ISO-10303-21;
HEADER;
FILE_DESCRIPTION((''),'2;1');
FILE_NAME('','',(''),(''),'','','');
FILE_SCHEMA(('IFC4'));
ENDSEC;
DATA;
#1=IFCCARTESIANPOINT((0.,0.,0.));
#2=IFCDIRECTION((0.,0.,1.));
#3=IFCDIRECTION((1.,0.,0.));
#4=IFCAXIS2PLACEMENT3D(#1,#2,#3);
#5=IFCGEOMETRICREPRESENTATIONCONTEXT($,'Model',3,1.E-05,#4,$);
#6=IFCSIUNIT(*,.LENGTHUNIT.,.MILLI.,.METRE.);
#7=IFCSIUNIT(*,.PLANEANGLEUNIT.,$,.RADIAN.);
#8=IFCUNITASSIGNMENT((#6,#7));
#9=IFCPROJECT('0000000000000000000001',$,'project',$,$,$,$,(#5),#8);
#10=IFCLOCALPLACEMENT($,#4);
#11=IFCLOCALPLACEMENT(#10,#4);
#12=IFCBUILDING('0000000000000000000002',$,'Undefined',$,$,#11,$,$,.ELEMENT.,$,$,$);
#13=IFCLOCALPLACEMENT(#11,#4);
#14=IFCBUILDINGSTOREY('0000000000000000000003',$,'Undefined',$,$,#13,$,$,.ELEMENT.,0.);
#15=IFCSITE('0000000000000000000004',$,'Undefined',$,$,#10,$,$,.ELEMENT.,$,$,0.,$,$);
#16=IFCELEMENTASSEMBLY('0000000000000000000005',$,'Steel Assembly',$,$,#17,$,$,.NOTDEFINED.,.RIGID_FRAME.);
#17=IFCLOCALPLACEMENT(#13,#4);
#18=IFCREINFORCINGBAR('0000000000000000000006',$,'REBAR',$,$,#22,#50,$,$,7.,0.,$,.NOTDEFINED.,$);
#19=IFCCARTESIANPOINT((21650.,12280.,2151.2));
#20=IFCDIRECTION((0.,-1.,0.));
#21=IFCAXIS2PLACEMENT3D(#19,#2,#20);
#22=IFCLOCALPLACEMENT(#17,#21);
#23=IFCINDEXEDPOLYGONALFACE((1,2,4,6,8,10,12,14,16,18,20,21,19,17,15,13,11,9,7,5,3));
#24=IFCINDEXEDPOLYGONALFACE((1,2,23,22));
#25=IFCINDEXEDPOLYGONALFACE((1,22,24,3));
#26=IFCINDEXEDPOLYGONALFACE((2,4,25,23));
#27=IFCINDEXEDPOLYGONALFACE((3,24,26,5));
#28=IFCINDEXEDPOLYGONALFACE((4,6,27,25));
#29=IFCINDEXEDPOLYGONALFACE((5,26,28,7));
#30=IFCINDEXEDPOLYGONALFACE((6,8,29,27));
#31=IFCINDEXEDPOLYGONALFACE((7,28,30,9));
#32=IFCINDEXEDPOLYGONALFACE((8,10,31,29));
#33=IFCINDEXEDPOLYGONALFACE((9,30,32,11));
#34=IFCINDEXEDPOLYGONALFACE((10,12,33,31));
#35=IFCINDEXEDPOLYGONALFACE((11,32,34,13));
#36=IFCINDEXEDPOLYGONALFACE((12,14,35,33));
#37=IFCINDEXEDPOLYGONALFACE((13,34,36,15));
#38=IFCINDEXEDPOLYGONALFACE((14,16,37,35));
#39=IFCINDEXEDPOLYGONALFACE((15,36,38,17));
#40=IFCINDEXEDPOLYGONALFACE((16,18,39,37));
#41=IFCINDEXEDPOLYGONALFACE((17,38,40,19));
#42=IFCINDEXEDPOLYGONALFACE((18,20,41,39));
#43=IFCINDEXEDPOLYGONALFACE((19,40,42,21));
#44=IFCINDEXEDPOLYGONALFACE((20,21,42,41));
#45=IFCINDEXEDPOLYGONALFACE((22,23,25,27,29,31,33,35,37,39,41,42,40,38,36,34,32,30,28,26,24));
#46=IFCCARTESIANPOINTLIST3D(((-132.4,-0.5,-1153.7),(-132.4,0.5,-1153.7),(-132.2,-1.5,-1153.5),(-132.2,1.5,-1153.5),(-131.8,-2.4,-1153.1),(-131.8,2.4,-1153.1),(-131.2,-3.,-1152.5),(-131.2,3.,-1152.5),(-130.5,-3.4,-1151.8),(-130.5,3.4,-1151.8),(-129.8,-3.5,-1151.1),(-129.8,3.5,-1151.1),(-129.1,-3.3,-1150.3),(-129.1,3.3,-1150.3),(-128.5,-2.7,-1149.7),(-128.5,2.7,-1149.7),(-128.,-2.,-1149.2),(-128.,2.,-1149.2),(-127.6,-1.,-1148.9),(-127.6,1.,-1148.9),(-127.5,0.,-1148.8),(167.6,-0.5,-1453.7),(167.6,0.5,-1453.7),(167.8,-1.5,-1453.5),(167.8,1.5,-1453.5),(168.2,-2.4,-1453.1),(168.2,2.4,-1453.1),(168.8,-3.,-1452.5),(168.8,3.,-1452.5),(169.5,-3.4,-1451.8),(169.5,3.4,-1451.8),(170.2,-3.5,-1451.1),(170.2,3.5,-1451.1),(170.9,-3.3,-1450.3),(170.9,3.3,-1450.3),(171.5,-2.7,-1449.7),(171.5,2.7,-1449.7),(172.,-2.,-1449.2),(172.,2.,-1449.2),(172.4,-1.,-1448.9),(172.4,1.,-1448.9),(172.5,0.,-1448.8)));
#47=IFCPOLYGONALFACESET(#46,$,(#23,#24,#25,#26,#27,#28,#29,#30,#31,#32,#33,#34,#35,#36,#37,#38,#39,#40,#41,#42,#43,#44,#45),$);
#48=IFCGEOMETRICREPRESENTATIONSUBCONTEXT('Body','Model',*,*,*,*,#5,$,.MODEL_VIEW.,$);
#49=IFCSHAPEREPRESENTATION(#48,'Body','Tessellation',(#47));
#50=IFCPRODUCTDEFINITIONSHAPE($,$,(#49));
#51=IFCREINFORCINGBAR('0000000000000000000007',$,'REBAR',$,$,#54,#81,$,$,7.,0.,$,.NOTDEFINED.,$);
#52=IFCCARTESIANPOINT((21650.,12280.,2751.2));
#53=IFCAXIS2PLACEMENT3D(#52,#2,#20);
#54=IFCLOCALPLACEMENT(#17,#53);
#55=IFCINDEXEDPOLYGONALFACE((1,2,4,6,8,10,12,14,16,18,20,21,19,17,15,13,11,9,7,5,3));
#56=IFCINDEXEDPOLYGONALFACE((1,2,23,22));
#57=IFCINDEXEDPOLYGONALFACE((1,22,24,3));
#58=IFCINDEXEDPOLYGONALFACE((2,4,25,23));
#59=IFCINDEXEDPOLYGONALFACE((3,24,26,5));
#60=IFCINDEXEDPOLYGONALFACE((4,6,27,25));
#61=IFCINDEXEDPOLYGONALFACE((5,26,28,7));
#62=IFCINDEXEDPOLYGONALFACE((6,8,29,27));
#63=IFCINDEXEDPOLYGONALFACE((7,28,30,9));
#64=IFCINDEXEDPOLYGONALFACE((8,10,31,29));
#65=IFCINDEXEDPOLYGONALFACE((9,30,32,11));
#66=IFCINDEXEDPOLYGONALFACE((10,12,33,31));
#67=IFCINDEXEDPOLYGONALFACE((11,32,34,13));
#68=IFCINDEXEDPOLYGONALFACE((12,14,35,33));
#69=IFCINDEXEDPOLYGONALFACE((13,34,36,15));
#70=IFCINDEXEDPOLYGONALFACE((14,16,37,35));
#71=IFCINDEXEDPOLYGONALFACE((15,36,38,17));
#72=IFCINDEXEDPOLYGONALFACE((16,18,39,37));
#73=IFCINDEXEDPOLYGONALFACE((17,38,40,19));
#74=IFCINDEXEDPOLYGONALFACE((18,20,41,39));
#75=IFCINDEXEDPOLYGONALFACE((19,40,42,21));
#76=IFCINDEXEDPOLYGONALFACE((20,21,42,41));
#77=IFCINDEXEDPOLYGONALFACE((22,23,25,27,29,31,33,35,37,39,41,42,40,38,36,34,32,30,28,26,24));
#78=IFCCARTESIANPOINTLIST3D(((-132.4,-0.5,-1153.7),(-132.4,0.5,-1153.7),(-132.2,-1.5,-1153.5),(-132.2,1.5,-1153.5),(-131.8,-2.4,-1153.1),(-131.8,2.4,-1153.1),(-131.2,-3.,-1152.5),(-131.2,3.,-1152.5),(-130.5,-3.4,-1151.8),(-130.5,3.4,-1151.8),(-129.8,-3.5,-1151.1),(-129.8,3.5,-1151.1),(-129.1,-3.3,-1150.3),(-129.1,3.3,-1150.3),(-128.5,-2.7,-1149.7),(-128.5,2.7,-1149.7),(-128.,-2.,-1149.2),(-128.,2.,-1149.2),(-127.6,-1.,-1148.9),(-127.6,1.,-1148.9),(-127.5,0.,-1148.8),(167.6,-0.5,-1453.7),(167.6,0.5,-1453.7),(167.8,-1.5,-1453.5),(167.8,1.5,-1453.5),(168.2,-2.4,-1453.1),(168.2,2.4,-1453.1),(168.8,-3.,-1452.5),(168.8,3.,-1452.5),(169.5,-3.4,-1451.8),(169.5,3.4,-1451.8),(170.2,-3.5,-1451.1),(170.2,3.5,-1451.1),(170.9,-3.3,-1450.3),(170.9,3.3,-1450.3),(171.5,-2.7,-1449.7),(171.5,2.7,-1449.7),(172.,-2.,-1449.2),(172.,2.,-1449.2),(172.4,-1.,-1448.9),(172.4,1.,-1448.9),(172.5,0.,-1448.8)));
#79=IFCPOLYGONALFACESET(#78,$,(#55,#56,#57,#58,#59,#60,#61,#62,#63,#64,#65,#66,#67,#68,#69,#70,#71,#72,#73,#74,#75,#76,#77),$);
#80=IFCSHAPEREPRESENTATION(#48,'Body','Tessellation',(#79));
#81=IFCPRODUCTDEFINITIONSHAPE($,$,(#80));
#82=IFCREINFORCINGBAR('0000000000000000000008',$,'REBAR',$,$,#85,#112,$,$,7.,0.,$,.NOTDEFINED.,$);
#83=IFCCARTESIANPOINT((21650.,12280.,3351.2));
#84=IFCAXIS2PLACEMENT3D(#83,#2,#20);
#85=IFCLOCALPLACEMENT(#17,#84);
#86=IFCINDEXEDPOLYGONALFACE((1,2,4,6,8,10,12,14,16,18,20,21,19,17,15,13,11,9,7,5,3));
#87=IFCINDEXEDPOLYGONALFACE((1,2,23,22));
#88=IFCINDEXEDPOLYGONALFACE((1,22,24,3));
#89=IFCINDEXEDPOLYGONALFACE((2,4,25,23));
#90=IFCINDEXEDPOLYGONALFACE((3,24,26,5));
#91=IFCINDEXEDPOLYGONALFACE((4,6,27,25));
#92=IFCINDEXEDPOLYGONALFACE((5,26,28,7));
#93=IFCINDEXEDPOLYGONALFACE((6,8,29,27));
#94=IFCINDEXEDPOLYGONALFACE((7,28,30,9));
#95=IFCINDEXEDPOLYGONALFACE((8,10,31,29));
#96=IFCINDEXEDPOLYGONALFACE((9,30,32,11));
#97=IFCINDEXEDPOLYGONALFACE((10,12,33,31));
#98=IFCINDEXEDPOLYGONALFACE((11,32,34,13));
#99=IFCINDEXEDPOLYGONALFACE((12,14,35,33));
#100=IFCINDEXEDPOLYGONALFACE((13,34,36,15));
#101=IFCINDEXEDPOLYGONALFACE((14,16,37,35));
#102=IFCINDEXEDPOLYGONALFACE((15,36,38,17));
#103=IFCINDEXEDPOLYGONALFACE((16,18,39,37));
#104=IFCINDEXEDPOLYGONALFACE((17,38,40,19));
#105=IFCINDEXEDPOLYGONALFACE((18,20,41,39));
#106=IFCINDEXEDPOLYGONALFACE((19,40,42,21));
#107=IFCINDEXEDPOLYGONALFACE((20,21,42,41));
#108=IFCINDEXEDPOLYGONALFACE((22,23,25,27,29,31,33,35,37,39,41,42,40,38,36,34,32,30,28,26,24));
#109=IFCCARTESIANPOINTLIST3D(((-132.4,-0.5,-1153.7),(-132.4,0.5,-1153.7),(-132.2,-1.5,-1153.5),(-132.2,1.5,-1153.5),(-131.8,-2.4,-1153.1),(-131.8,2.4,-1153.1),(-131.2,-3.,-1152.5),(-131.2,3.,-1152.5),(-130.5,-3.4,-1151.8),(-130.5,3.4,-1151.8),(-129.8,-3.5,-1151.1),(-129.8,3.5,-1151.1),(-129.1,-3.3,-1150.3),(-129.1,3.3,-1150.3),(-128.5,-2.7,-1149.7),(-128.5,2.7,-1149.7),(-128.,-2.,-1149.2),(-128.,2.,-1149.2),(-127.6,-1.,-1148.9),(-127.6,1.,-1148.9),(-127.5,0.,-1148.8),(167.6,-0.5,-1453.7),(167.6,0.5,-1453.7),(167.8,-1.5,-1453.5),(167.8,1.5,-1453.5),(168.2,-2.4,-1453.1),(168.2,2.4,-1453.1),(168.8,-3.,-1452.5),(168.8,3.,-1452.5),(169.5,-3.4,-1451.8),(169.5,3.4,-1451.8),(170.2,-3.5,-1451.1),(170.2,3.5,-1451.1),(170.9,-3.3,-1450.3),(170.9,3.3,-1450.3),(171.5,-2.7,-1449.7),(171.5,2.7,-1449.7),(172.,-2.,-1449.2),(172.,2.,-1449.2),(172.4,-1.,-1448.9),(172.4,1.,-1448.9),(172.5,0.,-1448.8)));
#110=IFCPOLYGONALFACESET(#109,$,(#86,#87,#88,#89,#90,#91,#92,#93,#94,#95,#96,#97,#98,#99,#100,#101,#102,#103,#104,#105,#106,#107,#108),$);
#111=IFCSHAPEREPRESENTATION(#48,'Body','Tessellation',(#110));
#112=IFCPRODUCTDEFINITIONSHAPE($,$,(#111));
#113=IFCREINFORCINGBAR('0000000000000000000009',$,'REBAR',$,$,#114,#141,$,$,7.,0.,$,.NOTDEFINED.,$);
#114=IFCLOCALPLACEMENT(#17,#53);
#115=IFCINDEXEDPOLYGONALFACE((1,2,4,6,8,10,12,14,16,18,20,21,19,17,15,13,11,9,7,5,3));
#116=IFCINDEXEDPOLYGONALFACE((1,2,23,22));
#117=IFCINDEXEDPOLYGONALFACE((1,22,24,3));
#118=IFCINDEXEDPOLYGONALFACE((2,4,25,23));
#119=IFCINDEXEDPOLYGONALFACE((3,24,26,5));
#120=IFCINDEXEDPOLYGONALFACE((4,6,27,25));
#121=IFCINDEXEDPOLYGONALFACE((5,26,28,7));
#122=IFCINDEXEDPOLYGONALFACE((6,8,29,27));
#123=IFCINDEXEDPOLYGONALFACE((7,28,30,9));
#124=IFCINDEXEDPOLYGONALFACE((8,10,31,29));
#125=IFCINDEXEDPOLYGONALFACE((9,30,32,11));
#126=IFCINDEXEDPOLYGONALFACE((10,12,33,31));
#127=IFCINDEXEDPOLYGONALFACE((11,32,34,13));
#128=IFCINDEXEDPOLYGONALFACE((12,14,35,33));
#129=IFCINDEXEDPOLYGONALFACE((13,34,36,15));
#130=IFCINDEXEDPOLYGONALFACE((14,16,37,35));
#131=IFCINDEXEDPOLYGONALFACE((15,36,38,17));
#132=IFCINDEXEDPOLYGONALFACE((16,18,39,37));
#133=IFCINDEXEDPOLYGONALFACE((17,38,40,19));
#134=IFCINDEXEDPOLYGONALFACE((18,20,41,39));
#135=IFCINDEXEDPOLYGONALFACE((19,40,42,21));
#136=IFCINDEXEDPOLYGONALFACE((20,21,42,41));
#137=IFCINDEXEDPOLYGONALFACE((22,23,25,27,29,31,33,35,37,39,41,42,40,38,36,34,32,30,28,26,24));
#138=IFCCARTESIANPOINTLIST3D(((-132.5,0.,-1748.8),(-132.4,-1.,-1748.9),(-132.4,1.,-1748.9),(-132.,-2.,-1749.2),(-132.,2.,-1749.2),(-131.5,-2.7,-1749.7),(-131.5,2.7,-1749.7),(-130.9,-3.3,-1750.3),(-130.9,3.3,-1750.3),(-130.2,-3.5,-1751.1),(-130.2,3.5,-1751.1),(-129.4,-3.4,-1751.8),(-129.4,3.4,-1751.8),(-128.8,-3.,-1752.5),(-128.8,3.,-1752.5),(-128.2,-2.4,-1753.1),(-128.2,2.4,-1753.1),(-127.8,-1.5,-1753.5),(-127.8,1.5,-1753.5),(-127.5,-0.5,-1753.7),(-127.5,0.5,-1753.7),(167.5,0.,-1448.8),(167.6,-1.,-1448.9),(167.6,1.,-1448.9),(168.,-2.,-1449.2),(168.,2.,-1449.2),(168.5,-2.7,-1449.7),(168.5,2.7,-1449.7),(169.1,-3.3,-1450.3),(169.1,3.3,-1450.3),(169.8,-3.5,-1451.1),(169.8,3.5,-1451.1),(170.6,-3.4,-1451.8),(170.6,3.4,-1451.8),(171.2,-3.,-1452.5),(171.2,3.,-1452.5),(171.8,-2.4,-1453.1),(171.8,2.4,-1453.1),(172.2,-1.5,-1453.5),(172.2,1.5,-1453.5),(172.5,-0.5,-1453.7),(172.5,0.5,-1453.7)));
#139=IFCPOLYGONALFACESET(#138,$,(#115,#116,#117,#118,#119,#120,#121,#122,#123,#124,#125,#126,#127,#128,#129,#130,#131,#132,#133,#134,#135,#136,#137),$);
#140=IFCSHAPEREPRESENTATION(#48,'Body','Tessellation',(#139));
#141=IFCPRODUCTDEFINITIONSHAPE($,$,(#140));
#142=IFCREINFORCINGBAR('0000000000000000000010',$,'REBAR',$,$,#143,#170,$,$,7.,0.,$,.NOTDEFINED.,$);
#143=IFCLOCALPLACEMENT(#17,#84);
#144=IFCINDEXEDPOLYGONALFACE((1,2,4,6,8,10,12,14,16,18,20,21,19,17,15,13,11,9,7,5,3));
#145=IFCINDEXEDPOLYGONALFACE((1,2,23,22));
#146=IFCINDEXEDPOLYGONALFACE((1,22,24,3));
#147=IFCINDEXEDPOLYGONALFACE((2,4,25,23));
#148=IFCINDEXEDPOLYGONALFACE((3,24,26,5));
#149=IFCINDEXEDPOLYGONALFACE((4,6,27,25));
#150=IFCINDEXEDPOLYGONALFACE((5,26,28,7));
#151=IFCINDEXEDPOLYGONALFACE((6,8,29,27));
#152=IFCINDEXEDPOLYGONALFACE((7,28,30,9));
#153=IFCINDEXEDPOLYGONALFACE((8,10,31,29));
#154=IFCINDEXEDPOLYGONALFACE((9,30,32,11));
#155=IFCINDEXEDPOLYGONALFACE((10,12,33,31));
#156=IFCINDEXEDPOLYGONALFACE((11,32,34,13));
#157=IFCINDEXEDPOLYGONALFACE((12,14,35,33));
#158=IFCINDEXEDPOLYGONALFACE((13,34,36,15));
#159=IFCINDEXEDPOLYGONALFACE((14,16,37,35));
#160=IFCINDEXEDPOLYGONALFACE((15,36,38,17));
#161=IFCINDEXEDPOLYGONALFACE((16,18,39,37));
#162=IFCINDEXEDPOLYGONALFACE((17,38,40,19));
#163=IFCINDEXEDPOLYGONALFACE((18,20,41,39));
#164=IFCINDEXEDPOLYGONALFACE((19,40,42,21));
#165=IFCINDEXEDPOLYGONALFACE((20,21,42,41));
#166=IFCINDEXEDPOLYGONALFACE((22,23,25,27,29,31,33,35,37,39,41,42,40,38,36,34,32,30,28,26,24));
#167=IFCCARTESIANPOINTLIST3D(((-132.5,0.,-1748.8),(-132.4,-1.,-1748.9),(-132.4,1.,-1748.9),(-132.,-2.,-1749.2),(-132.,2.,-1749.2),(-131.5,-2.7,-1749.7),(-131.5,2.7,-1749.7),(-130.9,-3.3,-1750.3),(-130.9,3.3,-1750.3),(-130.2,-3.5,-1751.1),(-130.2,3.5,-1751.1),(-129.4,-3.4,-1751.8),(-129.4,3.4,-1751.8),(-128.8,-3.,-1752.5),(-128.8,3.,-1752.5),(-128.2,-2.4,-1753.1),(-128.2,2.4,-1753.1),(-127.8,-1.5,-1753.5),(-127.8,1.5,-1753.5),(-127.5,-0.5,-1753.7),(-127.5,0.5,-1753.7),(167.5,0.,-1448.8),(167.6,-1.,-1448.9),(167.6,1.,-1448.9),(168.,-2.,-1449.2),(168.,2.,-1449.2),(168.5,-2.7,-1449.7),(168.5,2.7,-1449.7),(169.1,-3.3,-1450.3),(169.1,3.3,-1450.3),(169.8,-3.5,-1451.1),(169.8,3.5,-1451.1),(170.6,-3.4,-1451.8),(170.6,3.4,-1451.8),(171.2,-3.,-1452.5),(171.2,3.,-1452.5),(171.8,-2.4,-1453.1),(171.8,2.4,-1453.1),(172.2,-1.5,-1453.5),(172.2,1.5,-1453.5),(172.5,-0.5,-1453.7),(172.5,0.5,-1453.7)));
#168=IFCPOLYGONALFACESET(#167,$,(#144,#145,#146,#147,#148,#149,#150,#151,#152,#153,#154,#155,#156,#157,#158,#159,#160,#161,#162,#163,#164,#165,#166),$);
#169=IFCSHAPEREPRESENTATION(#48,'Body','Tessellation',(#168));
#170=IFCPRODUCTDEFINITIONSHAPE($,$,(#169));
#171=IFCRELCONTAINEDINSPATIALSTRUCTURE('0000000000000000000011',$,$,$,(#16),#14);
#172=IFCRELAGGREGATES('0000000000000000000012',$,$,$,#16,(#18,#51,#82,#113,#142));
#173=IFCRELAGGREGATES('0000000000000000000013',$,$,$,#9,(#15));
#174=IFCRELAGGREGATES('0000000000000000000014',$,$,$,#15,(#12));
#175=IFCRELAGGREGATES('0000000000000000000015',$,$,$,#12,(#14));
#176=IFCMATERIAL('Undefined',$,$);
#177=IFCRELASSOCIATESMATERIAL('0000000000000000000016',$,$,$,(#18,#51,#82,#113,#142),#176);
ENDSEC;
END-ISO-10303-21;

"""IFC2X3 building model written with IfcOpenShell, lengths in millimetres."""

from ifc_helpers import new_model, entity, si_unit, frame, origin_with_axes, place, context, subcontext, project, spatial, source, transform, mapped, material, element, aggregate, save


model = new_model("IFC2X3")

# Units and contexts
model_context = context("Model", 3, precision=1e-05, world=origin_with_axes())
body_context = subcontext(model_context, "Body", "Model", "MODEL_VIEW")
ifc_project = project(units=[si_unit("LENGTHUNIT", "METRE", prefix="MILLI"), si_unit("PLANEANGLEUNIT", "RADIAN")], contexts=[model_context])

# Site, building, storey
site_placement = place(None, origin_with_axes())
site = spatial("IfcSite", under=ifc_project, at=site_placement, Name="Undefined", CompositionType="ELEMENT", RefElevation=0.0)
building_placement = place(site_placement, origin_with_axes())
building = spatial("IfcBuilding", under=site, at=building_placement, Name="Undefined", CompositionType="ELEMENT")
storey_placement = place(building_placement, origin_with_axes())
storey = spatial("IfcBuildingStorey", under=building, at=storey_placement, Name="Undefined", CompositionType="ELEMENT", Elevation=0.0)

# Shared definitions
ifc_material_1 = material(Name="Undefined")

# Element assembly, reinforcing bars
assembly_1_placement = place(storey_placement, origin_with_axes())
assembly_1 = element("IfcElementAssembly", 1, at=assembly_1_placement, inside=storey, Name="Steel Assembly", AssemblyPlace="NOTDEFINED", PredefinedType="RIGID_FRAME")
shared_shape_1 = source(origin_with_axes(), body_context, "Body", "AdvancedSweptSolid", [
    entity("IfcSweptDiskSolid", entity("IfcTrimmedCurve", entity("IfcLine", entity("IfcCartesianPoint", [0.0, 0.0, 0.0]), entity("IfcVector", entity("IfcDirection", [0.707107, 0.0, -0.707107]), 1.0)), [entity("IfcParameterValue", 0.0)], [entity("IfcParameterValue", 424.264069)], True, "PARAMETER"), 3.5, None, 0.0, 424.3),
])
reinforcing_bar_1_placement = place(assembly_1_placement, frame((21650.0, 12280.0, 2151.2), z_axis=(0.0, 0.0, 1.0), x_axis=(0.0, -1.0, 0.0)))
reinforcing_bar_1 = element("IfcReinforcingBar", 2, at=reinforcing_bar_1_placement, material=ifc_material_1, Name="REBAR", BarRole="NOTDEFINED", CrossSectionArea=0.0, NominalDiameter=7.0, context=body_context, shape_type="MappedRepresentation", body=[
    mapped(shared_shape_1, transform((-130.0, 0.0, -1151.2))),
])
shared_shape_2 = source(origin_with_axes(), body_context, "Body", "AdvancedSweptSolid", [
    entity("IfcSweptDiskSolid", entity("IfcTrimmedCurve", entity("IfcLine", entity("IfcCartesianPoint", [0.0, 0.0, 0.0]), entity("IfcVector", entity("IfcDirection", [0.707107, 0.0, -0.707107]), 1.0)), [entity("IfcParameterValue", 0.0)], [entity("IfcParameterValue", 424.264069)], True, "PARAMETER"), 3.5, None, 0.0, 424.3),
])
reinforcing_bar_2_placement = place(assembly_1_placement, frame((21650.0, 12280.0, 2751.2), z_axis=(0.0, 0.0, 1.0), x_axis=(0.0, -1.0, 0.0)))
reinforcing_bar_2 = element("IfcReinforcingBar", 3, at=reinforcing_bar_2_placement, material=ifc_material_1, Name="REBAR", BarRole="NOTDEFINED", CrossSectionArea=0.0, NominalDiameter=7.0, context=body_context, shape_type="MappedRepresentation", body=[
    mapped(shared_shape_2, transform((-130.0, 0.0, -1151.2))),
])
shared_shape_3 = source(origin_with_axes(), body_context, "Body", "AdvancedSweptSolid", [
    entity("IfcSweptDiskSolid", entity("IfcTrimmedCurve", entity("IfcLine", entity("IfcCartesianPoint", [0.0, 0.0, 0.0]), entity("IfcVector", entity("IfcDirection", [0.707107, 0.0, -0.707107]), 1.0)), [entity("IfcParameterValue", 0.0)], [entity("IfcParameterValue", 424.264069)], True, "PARAMETER"), 3.5, None, 0.0, 424.3),
])
reinforcing_bar_3_placement = place(assembly_1_placement, frame((21650.0, 12280.0, 3351.2), z_axis=(0.0, 0.0, 1.0), x_axis=(0.0, -1.0, 0.0)))
reinforcing_bar_3 = element("IfcReinforcingBar", 4, at=reinforcing_bar_3_placement, material=ifc_material_1, Name="REBAR", BarRole="NOTDEFINED", CrossSectionArea=0.0, NominalDiameter=7.0, context=body_context, shape_type="MappedRepresentation", body=[
    mapped(shared_shape_3, transform((-130.0, 0.0, -1151.2))),
])
shared_shape_4 = source(origin_with_axes(), body_context, "Body", "AdvancedSweptSolid", [
    entity("IfcSweptDiskSolid", entity("IfcTrimmedCurve", entity("IfcLine", entity("IfcCartesianPoint", [0.0, 0.0, 0.0]), entity("IfcVector", entity("IfcDirection", [0.707107, 0.0, 0.707107]), 1.0)), [entity("IfcParameterValue", 0.0)], [entity("IfcParameterValue", 424.264069)], True, "PARAMETER"), 3.5, None, 0.0, 424.3),
])
reinforcing_bar_4_placement = place(assembly_1_placement, frame((21650.0, 12280.0, 2751.2), z_axis=(0.0, 0.0, 1.0), x_axis=(0.0, -1.0, 0.0)))
reinforcing_bar_4 = element("IfcReinforcingBar", 5, at=reinforcing_bar_4_placement, material=ifc_material_1, Name="REBAR", BarRole="NOTDEFINED", CrossSectionArea=0.0, NominalDiameter=7.0, context=body_context, shape_type="MappedRepresentation", body=[
    mapped(shared_shape_4, transform((-130.0, 0.0, -1751.2))),
])
shared_shape_5 = source(origin_with_axes(), body_context, "Body", "AdvancedSweptSolid", [
    entity("IfcSweptDiskSolid", entity("IfcTrimmedCurve", entity("IfcLine", entity("IfcCartesianPoint", [0.0, 0.0, 0.0]), entity("IfcVector", entity("IfcDirection", [0.707107, 0.0, 0.707107]), 1.0)), [entity("IfcParameterValue", 0.0)], [entity("IfcParameterValue", 424.264069)], True, "PARAMETER"), 3.5, None, 0.0, 424.3),
])
reinforcing_bar_5_placement = place(assembly_1_placement, frame((21650.0, 12280.0, 3351.2), z_axis=(0.0, 0.0, 1.0), x_axis=(0.0, -1.0, 0.0)))
reinforcing_bar_5 = element("IfcReinforcingBar", 6, at=reinforcing_bar_5_placement, material=ifc_material_1, Name="REBAR", BarRole="NOTDEFINED", CrossSectionArea=0.0, NominalDiameter=7.0, context=body_context, shape_type="MappedRepresentation", body=[
    mapped(shared_shape_5, transform((-130.0, 0.0, -1751.2))),
])
aggregate(assembly_1, [reinforcing_bar_1, reinforcing_bar_2, reinforcing_bar_3, reinforcing_bar_4, reinforcing_bar_5])

save(model, "model.ifc")
